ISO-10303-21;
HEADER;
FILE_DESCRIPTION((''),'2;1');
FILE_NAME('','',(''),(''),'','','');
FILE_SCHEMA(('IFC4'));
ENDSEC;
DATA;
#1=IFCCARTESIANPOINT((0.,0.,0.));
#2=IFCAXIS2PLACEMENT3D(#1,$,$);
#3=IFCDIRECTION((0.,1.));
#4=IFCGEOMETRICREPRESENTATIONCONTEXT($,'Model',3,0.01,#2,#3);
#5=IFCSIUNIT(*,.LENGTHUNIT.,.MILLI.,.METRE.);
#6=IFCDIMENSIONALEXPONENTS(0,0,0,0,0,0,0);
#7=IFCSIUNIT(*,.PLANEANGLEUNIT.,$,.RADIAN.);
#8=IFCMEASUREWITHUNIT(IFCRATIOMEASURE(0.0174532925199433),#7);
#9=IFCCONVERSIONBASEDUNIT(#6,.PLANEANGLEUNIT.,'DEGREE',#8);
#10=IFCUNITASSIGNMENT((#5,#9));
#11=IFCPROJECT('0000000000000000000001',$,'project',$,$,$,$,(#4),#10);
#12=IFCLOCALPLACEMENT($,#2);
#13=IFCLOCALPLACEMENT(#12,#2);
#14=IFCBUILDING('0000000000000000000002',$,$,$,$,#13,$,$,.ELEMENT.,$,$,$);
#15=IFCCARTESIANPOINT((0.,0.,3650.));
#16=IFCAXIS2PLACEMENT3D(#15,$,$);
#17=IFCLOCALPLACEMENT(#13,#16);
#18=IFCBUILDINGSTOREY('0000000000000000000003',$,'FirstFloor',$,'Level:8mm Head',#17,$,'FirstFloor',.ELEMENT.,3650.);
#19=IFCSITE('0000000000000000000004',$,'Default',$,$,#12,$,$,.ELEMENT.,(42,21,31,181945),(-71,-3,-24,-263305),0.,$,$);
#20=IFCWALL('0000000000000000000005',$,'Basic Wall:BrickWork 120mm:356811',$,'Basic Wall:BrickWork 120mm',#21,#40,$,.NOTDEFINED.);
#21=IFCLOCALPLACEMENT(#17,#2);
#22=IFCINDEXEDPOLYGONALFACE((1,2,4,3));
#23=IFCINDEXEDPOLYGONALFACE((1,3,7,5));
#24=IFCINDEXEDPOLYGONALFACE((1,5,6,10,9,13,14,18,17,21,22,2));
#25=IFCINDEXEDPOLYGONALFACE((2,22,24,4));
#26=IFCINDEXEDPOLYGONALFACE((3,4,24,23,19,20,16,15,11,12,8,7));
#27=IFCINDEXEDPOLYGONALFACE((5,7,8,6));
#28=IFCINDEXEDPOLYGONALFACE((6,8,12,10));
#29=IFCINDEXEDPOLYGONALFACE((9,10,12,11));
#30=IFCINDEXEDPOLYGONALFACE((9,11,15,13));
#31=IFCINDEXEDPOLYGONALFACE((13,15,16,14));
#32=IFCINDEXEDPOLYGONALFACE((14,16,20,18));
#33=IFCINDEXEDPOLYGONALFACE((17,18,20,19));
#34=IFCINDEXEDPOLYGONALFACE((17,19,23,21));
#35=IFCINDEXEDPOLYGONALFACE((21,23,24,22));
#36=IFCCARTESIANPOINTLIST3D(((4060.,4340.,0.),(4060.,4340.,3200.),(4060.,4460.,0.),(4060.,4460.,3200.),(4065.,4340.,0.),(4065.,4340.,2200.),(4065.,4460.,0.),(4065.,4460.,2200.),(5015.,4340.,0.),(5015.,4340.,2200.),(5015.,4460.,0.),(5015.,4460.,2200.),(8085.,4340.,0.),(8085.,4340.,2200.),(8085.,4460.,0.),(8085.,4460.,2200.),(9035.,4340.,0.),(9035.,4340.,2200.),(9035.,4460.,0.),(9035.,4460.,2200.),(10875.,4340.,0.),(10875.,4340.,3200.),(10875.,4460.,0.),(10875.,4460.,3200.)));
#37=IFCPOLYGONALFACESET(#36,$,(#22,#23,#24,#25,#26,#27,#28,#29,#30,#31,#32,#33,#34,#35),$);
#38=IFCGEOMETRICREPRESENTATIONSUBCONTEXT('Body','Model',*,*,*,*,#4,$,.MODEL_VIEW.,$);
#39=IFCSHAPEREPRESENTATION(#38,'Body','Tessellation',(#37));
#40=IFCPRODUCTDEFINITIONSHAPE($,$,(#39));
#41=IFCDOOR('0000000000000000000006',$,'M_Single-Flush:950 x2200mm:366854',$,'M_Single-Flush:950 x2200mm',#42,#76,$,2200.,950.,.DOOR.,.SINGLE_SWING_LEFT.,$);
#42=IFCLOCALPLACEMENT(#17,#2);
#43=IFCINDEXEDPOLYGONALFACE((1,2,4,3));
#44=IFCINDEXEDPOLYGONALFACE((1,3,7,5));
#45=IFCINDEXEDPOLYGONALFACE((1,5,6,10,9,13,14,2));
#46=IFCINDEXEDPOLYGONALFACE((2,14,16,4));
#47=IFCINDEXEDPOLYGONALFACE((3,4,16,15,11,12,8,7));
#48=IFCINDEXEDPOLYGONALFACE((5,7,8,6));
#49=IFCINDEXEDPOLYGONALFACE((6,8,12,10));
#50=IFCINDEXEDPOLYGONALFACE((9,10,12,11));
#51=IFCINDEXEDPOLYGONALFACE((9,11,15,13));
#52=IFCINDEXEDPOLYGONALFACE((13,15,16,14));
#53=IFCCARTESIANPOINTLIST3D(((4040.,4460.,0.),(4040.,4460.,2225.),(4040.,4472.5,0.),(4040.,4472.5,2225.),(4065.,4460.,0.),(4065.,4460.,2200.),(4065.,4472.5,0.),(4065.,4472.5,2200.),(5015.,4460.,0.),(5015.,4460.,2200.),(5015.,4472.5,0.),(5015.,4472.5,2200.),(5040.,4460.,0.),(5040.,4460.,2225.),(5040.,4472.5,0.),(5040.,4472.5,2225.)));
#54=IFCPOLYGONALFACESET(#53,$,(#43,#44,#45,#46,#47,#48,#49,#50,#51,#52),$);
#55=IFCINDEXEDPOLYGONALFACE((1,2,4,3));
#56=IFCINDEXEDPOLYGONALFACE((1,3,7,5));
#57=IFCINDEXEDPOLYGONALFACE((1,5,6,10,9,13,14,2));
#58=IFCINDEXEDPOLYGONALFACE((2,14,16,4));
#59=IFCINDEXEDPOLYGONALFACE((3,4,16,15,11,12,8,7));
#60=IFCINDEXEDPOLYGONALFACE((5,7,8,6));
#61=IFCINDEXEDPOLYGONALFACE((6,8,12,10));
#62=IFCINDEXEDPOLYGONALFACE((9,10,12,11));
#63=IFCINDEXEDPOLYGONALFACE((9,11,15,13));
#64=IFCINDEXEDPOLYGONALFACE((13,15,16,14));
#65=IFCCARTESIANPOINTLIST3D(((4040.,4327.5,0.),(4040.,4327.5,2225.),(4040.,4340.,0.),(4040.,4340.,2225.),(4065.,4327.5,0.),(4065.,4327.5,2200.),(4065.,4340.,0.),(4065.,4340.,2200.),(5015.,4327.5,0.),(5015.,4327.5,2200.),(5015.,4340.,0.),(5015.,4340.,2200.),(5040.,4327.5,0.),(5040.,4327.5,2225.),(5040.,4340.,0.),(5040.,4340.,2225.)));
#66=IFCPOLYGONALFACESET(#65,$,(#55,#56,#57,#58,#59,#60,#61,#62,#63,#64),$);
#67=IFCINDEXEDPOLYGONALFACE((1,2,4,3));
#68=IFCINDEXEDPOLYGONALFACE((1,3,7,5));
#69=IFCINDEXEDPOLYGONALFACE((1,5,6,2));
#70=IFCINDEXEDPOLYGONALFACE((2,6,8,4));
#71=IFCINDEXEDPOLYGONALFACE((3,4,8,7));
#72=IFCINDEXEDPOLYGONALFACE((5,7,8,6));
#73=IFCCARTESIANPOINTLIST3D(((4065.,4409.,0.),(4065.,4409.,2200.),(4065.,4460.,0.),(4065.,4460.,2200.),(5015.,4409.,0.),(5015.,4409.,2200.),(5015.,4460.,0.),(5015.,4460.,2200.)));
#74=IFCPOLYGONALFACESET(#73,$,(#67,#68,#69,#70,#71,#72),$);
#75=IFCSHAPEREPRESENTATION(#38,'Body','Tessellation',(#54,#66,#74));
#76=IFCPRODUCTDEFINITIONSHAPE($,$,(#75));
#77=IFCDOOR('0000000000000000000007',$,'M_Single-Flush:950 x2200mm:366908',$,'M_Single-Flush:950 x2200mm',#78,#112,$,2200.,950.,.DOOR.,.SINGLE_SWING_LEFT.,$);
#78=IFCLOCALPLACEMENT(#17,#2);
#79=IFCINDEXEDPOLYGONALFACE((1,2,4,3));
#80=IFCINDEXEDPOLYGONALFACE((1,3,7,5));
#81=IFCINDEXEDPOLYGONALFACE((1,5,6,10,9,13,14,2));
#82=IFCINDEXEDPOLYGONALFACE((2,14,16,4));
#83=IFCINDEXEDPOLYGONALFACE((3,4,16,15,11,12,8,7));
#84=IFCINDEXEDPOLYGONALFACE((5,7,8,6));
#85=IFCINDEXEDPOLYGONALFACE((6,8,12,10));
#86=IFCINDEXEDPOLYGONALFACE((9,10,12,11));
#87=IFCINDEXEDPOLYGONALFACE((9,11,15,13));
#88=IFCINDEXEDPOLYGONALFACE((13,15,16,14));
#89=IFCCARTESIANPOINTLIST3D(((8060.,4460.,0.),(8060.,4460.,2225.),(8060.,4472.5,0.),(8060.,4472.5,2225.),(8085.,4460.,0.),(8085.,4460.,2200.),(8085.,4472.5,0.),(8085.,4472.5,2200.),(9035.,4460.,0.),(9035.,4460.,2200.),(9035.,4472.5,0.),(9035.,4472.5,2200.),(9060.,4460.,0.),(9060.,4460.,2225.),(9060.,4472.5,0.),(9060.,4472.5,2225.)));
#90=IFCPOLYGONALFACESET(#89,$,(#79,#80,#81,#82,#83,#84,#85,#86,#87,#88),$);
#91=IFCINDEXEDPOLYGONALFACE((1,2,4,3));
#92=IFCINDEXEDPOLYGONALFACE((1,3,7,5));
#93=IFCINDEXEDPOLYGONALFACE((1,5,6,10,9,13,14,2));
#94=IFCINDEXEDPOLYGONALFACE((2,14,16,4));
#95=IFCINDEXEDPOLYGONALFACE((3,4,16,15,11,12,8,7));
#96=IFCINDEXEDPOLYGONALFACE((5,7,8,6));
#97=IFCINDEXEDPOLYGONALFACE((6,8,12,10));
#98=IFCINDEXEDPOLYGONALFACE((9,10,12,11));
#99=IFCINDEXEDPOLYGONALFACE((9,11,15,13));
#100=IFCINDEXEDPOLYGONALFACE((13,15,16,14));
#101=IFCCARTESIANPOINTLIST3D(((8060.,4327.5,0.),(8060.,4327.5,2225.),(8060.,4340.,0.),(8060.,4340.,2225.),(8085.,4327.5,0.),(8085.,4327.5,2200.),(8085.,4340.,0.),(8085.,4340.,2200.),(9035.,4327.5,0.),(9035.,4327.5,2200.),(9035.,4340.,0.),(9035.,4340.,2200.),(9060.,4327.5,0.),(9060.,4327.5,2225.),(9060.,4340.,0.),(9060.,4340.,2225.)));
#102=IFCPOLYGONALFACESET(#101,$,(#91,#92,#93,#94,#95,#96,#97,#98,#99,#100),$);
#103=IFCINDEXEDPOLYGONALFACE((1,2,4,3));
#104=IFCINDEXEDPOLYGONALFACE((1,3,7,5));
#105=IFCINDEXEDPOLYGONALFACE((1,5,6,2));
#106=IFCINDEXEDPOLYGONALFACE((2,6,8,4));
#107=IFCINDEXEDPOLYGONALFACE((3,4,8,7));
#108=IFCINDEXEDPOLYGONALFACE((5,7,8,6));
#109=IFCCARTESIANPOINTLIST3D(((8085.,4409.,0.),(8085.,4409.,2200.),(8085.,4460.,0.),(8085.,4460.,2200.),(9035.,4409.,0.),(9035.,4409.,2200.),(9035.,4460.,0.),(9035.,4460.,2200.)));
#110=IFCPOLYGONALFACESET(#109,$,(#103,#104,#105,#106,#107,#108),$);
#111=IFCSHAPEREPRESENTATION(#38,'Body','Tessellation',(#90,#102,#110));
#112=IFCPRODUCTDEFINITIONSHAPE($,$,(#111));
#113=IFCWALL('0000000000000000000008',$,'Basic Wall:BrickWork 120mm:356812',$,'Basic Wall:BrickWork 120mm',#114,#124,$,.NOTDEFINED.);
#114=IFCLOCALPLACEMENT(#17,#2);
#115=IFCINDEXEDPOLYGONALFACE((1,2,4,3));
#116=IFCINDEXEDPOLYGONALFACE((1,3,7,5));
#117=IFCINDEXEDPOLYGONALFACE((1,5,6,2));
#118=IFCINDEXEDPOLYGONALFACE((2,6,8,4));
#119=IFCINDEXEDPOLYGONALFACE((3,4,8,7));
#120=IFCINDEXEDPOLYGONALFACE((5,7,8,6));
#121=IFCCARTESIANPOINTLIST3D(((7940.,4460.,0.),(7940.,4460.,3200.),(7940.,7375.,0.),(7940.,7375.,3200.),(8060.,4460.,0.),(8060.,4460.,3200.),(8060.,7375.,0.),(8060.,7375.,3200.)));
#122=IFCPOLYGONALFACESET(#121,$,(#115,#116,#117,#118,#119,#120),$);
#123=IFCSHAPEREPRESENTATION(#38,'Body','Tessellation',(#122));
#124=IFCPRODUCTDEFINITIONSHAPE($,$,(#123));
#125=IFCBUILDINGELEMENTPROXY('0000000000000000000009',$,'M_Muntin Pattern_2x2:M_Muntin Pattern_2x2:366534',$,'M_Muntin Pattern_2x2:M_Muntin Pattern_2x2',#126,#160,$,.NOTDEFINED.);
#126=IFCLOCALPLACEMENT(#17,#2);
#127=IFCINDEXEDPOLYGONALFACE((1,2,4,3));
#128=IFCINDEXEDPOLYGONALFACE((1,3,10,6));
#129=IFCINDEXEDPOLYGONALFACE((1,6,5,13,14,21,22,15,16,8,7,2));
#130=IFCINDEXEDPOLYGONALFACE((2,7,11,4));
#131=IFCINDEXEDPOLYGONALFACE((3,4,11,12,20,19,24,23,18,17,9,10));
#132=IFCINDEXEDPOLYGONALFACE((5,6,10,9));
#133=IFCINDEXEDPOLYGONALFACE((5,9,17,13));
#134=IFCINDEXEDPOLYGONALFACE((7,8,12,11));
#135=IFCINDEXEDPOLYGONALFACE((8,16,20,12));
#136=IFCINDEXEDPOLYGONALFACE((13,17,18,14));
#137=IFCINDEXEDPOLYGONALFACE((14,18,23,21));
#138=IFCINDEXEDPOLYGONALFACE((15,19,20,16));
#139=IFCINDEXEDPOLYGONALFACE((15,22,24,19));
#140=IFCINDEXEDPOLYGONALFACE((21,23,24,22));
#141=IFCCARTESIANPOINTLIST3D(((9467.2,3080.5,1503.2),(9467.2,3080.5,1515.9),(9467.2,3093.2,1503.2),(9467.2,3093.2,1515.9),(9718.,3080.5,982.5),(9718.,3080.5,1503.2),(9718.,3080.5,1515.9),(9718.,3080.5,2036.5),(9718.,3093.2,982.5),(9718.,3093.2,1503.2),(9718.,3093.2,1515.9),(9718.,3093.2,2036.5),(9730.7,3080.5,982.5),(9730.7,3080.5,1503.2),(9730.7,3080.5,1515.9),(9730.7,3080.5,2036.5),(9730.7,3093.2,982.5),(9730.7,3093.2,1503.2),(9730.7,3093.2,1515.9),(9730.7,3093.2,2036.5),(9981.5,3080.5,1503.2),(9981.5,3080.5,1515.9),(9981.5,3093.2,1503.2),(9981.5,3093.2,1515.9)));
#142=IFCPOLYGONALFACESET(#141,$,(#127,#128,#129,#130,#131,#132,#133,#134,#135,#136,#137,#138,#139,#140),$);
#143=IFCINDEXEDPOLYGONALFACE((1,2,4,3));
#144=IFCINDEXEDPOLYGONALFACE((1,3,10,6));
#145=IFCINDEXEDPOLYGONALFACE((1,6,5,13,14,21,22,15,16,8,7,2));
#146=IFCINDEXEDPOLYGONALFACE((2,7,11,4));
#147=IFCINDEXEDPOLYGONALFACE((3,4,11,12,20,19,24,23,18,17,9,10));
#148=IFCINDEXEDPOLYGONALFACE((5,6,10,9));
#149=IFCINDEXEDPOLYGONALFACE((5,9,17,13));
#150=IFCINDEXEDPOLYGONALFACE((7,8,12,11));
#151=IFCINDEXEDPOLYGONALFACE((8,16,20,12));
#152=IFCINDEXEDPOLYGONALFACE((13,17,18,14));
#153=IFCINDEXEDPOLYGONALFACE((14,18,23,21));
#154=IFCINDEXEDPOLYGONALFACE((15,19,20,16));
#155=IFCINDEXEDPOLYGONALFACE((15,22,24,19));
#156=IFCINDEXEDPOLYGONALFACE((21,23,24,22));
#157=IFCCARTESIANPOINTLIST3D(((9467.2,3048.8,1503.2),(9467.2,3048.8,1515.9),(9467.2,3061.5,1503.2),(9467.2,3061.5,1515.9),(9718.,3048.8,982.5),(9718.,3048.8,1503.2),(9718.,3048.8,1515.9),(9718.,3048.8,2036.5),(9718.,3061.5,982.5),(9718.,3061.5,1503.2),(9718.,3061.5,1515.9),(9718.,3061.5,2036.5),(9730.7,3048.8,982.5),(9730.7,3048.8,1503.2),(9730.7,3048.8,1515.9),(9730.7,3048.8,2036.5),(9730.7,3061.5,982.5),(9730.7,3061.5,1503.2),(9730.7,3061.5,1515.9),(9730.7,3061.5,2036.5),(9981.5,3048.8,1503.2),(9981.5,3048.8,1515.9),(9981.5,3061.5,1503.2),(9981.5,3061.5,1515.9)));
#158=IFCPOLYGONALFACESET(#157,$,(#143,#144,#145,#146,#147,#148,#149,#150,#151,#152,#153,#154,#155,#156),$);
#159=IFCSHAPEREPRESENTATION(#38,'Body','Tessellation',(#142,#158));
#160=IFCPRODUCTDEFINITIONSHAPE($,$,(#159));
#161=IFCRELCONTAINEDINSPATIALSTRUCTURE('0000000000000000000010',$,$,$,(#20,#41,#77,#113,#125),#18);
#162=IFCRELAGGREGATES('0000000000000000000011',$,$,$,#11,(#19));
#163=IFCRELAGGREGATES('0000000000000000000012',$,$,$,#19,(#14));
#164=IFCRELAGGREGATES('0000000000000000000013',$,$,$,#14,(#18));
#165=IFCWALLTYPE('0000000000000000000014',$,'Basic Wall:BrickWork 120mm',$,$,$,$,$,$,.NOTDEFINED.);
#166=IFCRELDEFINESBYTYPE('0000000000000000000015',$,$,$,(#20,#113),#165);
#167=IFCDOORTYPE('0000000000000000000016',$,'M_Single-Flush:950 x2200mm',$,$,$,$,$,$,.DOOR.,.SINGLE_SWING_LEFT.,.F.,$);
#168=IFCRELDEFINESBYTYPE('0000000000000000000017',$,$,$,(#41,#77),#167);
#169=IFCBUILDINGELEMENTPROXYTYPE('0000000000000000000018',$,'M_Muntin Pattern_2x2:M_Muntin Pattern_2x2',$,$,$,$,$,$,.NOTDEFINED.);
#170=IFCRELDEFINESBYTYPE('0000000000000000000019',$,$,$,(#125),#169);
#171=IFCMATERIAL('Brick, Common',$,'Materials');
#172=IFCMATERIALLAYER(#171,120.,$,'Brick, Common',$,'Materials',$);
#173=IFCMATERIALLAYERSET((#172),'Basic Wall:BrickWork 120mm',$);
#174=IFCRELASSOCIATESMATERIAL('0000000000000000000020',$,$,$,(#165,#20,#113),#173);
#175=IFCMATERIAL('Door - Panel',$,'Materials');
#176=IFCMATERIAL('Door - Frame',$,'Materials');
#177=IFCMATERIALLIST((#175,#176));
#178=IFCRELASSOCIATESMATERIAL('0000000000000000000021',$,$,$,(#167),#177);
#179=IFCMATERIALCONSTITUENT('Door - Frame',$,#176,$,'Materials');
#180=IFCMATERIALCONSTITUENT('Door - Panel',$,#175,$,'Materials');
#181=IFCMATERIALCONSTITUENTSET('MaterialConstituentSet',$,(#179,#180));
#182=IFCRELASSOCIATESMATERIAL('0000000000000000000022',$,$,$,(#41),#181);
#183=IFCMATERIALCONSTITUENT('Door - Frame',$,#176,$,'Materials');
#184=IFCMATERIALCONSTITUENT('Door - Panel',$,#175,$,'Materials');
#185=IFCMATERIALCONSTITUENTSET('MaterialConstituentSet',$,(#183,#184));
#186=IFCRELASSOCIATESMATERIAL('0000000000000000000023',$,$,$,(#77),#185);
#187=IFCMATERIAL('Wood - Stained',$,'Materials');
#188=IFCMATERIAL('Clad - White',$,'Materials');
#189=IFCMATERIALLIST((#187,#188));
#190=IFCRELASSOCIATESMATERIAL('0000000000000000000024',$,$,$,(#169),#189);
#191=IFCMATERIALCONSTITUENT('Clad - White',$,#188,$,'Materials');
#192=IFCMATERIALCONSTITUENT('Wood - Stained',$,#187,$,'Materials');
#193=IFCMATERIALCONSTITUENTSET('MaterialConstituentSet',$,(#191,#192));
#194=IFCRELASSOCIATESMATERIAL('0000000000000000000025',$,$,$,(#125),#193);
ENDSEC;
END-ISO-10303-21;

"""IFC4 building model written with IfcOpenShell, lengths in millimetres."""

from ifc_helpers import new_model, entity, si_unit, converted_unit, direction, frame, frame_2d, origin, place, context, subcontext, project, spatial, polyline, rectangle, outline, extrude, source, transform, mapped, material, material_list, layer, layer_set, layer_usage, constituent, constituent_set, type_object, type_shapes, element, fill, save


model = new_model("IFC4")

# Units and contexts
model_context = context("Model", 3, precision=0.01, world=origin(), true_north=direction((0.0, 1.0)))
body_context = subcontext(model_context, "Body", "Model", "MODEL_VIEW")
ifc_project = project(units=[si_unit("LENGTHUNIT", "METRE", prefix="MILLI"), converted_unit("PLANEANGLEUNIT", "DEGREE", entity("IfcRatioMeasure", 0.0174532925199433), si_unit("PLANEANGLEUNIT", "RADIAN"), dimensions=[0, 0, 0, 0, 0, 0, 0])], contexts=[model_context])

# Site, building, storey
site_placement = place(None, origin())
site = spatial("IfcSite", under=ifc_project, at=site_placement, Name="Default", CompositionType="ELEMENT", RefLatitude=(42, 21, 31, 181945), RefLongitude=(-71, -3, -24, -263305), RefElevation=0.0)
building_placement = place(site_placement, origin())
building = spatial("IfcBuilding", under=site, at=building_placement, CompositionType="ELEMENT")
storey_placement = place(building_placement, frame((0.0, 0.0, 3650.0)))
storey = spatial("IfcBuildingStorey", under=building, at=storey_placement, Name="FirstFloor", ObjectType="Level:8mm Head", LongName="FirstFloor", CompositionType="ELEMENT", Elevation=3650.0)

# Shared definitions
ifc_material_1 = material(Name="Brick, Common", Category="Materials")

# Wall, openings, doors
ifc_layer_1 = layer(ifc_material_1, 120.0, Name="Brick, Common", Category="Materials")
ifc_layer_set_1 = layer_set([ifc_layer_1], Name="Basic Wall:BrickWork 120mm")
ifc_layer_usage_1 = layer_usage(ifc_layer_set_1, "AXIS2", "NEGATIVE", 60.0)
wall_type_1 = type_object("IfcWallType", Name="Basic Wall:BrickWork 120mm", PredefinedType="NOTDEFINED", material=ifc_layer_set_1)
wall_1_placement = place(storey_placement, frame((10875.0, 4400.0, 0.0), z_axis=(0.0, 0.0, 1.0), x_axis=(-1.0, 0.0, 0.0)))
wall_1 = element("IfcWall", 1, at=wall_1_placement, inside=storey, type_object=wall_type_1, material=ifc_layer_usage_1, Name="Basic Wall:BrickWork 120mm:356811", ObjectType="Basic Wall:BrickWork 120mm", PredefinedType="NOTDEFINED", context=body_context, shape_type="SweptSolid", body=[
    extrude(rectangle(XDim=6815.0, YDim=120.0, at=frame_2d((3407.5, 0.0), x_axis=(-1.0, 0.0))), origin(), (0.0, 0.0, 1.0), 3200.0),
])
opening_1_placement = place(wall_1_placement, frame((6810.0, 60.0, 0.0)))
opening_1 = element("IfcOpeningElement", 2, at=opening_1_placement, cuts=wall_1, ObjectType="Opening", PredefinedType="OPENING", context=body_context, shape_type="SweptSolid", body=[
    extrude(rectangle(XDim=950.0, YDim=2200.0, at=frame_2d((1100.0, 475.0), x_axis=(0.0, -1.0))), frame((0.0, 0.0, 0.0), z_axis=(0.0, -1.0, 0.0), x_axis=(0.0, 0.0, 1.0)), (0.0, 0.0, 1.0), 120.0),
])
opening_2_placement = place(wall_1_placement, frame((2790.0, 60.0, 0.0)))
opening_2 = element("IfcOpeningElement", 3, at=opening_2_placement, cuts=wall_1, ObjectType="Opening", PredefinedType="OPENING", context=body_context, shape_type="SweptSolid", body=[
    extrude(rectangle(XDim=950.0, YDim=2200.0, at=frame_2d((1100.0, 475.0), x_axis=(0.0, -1.0))), frame((0.0, 0.0, 0.0), z_axis=(0.0, -1.0, 0.0), x_axis=(0.0, 0.0, 1.0)), (0.0, 0.0, 1.0), 120.0),
])
ifc_material_2 = material(Name="Door - Frame", Category="Materials")
ifc_constituent_1 = constituent(ifc_material_2, Name="Door - Frame", Category="Materials")
ifc_material_3 = material(Name="Door - Panel", Category="Materials")
ifc_constituent_2 = constituent(ifc_material_3, Name="Door - Panel", Category="Materials")
ifc_constituent_set_1 = constituent_set(constituents=[ifc_constituent_1, ifc_constituent_2], Name="MaterialConstituentSet")
ifc_material_list_1 = material_list([ifc_material_3, ifc_material_2])
door_type = type_object("IfcDoorType", Name="M_Single-Flush:950 x2200mm", OperationType="SINGLE_SWING_LEFT", ParameterTakesPrecedence=False, PredefinedType="DOOR", material=ifc_material_list_1)
shared_shape_1 = source(origin(), body_context, "Body", "SweptSolid", [
    extrude(outline(polyline([(-500.0, -1118.8), (500.0, -1118.8), (500.0, 1106.2), (475.0, 1106.2), (475.0, -1093.8), (-475.0, -1093.8), (-475.0, 1106.2), (-500.0, 1106.2), (-500.0, -1118.8)])), frame((475.0, 132.5, 1106.2), z_axis=(0.0, -1.0, 0.0), x_axis=(-1.0, 0.0, 0.0)), (0.0, 0.0, 1.0), 12.5),
    extrude(outline(polyline([(-1118.8, -500.0), (1106.2, -500.0), (1106.2, -475.0), (-1093.8, -475.0), (-1093.8, 475.0), (1106.2, 475.0), (1106.2, 500.0), (-1118.8, 500.0), (-1118.8, -500.0)])), frame((475.0, 0.0, 1106.2), z_axis=(0.0, -1.0, 0.0), x_axis=(0.0, 0.0, -1.0)), (0.0, 0.0, 1.0), 12.5),
    extrude(rectangle(XDim=950.0, YDim=51.0, at=frame_2d((0.0, 0.0), x_axis=(1.0, 0.0))), frame((475.0, 94.5, 0.0)), (0.0, 0.0, 1.0), 2200.0),
])
type_shapes(door_type, [shared_shape_1])
door_1_placement = place(opening_1_placement, frame((0.0, 0.0, 0.0), z_axis=(0.0, 0.0, 1.0), x_axis=(-1.0, 0.0, 0.0)))
door_1 = element("IfcDoor", 4, at=door_1_placement, inside=storey, type_object=door_type, material=ifc_constituent_set_1, Name="M_Single-Flush:950 x2200mm:366854", ObjectType="M_Single-Flush:950 x2200mm", OperationType="SINGLE_SWING_LEFT", OverallHeight=2200.0, OverallWidth=950.0, PredefinedType="DOOR", context=body_context, shape_type="MappedRepresentation", body=[
    mapped(shared_shape_1, transform((0.0, 0.0, 0.0), scale=1.0)),
])
fill(opening_1, door_1)
ifc_constituent_3 = constituent(ifc_material_2, Name="Door - Frame", Category="Materials")
ifc_constituent_4 = constituent(ifc_material_3, Name="Door - Panel", Category="Materials")
ifc_constituent_set_2 = constituent_set(constituents=[ifc_constituent_3, ifc_constituent_4], Name="MaterialConstituentSet")
door_2_placement = place(opening_2_placement, frame((0.0, 0.0, 0.0), z_axis=(0.0, 0.0, 1.0), x_axis=(-1.0, 0.0, 0.0)))
door_2 = element("IfcDoor", 5, at=door_2_placement, inside=storey, type_object=door_type, material=ifc_constituent_set_2, Name="M_Single-Flush:950 x2200mm:366908", ObjectType="M_Single-Flush:950 x2200mm", OperationType="SINGLE_SWING_LEFT", OverallHeight=2200.0, OverallWidth=950.0, PredefinedType="DOOR", context=body_context, shape_type="MappedRepresentation", body=[
    mapped(shared_shape_1, transform((0.0, 0.0, 0.0), scale=1.0)),
])
fill(opening_2, door_2)

# Wall
ifc_layer_usage_2 = layer_usage(ifc_layer_set_1, "AXIS2", "NEGATIVE", 60.0)
wall_2_placement = place(storey_placement, frame((8000.0, 7375.0, 0.0), z_axis=(0.0, 0.0, 1.0), x_axis=(0.0, -1.0, 0.0)))
element("IfcWall", 6, at=wall_2_placement, inside=storey, type_object=wall_type_1, material=ifc_layer_usage_2, Name="Basic Wall:BrickWork 120mm:356812", ObjectType="Basic Wall:BrickWork 120mm", PredefinedType="NOTDEFINED", context=body_context, shape_type="SweptSolid", body=[
    extrude(rectangle(XDim=2915.0, YDim=120.0, at=frame_2d((1457.5, 0.0), x_axis=(-1.0, 0.0))), origin(), (0.0, 0.0, 1.0), 3200.0),
])

# Building element proxy
ifc_material_4 = material(Name="Clad - White", Category="Materials")
ifc_constituent_5 = constituent(ifc_material_4, Name="Clad - White", Category="Materials")
ifc_material_5 = material(Name="Wood - Stained", Category="Materials")
ifc_constituent_6 = constituent(ifc_material_5, Name="Wood - Stained", Category="Materials")
ifc_constituent_set_3 = constituent_set(constituents=[ifc_constituent_5, ifc_constituent_6], Name="MaterialConstituentSet")
ifc_material_list_2 = material_list([ifc_material_5, ifc_material_4])
building_element_proxy_type_1 = type_object("IfcBuildingElementProxyType", Name="M_Muntin Pattern_2x2:M_Muntin Pattern_2x2", PredefinedType="NOTDEFINED", material=ifc_material_list_2)
shared_shape_2 = source(origin(), body_context, "Body", "SweptSolid", [
    extrude(outline(polyline([(6.4, -6.4), (527.0, -6.4), (527.0, 6.3), (6.4, 6.3), (6.4, 257.1), (-6.3, 257.1), (-6.3, 6.3), (-527.0, 6.3), (-527.0, -6.4), (-6.3, -6.4), (-6.3, -257.1), (6.4, -257.1), (6.4, -6.4)])), frame((0.0, 9.5, 527.0), z_axis=(0.0, 1.0, 0.0), x_axis=(0.0, 0.0, 1.0)), (0.0, 0.0, 1.0), 12.7),
    extrude(outline(polyline([(6.4, -6.4), (527.0, -6.4), (527.0, 6.3), (6.4, 6.3), (6.4, 257.1), (-6.3, 257.1), (-6.3, 6.3), (-527.0, 6.3), (-527.0, -6.4), (-6.3, -6.4), (-6.3, -257.1), (6.4, -257.1), (6.4, -6.4)])), frame((0.0, -22.2, 527.0), z_axis=(0.0, 1.0, 0.0), x_axis=(0.0, 0.0, 1.0)), (0.0, 0.0, 1.0), 12.7),
])
type_shapes(building_element_proxy_type_1, [shared_shape_2])
proxy_1_placement = place(storey_placement, frame((9724.4, 3071.0, 982.5)))
element("IfcBuildingElementProxy", 7, at=proxy_1_placement, inside=storey, type_object=building_element_proxy_type_1, material=ifc_constituent_set_3, Name="M_Muntin Pattern_2x2:M_Muntin Pattern_2x2:366534", ObjectType="M_Muntin Pattern_2x2:M_Muntin Pattern_2x2", PredefinedType="NOTDEFINED", context=body_context, shape_type="MappedRepresentation", body=[
    mapped(shared_shape_2, transform((0.0, 0.0, 0.0), scale=1.0)),
])

save(model, "model.ifc")
